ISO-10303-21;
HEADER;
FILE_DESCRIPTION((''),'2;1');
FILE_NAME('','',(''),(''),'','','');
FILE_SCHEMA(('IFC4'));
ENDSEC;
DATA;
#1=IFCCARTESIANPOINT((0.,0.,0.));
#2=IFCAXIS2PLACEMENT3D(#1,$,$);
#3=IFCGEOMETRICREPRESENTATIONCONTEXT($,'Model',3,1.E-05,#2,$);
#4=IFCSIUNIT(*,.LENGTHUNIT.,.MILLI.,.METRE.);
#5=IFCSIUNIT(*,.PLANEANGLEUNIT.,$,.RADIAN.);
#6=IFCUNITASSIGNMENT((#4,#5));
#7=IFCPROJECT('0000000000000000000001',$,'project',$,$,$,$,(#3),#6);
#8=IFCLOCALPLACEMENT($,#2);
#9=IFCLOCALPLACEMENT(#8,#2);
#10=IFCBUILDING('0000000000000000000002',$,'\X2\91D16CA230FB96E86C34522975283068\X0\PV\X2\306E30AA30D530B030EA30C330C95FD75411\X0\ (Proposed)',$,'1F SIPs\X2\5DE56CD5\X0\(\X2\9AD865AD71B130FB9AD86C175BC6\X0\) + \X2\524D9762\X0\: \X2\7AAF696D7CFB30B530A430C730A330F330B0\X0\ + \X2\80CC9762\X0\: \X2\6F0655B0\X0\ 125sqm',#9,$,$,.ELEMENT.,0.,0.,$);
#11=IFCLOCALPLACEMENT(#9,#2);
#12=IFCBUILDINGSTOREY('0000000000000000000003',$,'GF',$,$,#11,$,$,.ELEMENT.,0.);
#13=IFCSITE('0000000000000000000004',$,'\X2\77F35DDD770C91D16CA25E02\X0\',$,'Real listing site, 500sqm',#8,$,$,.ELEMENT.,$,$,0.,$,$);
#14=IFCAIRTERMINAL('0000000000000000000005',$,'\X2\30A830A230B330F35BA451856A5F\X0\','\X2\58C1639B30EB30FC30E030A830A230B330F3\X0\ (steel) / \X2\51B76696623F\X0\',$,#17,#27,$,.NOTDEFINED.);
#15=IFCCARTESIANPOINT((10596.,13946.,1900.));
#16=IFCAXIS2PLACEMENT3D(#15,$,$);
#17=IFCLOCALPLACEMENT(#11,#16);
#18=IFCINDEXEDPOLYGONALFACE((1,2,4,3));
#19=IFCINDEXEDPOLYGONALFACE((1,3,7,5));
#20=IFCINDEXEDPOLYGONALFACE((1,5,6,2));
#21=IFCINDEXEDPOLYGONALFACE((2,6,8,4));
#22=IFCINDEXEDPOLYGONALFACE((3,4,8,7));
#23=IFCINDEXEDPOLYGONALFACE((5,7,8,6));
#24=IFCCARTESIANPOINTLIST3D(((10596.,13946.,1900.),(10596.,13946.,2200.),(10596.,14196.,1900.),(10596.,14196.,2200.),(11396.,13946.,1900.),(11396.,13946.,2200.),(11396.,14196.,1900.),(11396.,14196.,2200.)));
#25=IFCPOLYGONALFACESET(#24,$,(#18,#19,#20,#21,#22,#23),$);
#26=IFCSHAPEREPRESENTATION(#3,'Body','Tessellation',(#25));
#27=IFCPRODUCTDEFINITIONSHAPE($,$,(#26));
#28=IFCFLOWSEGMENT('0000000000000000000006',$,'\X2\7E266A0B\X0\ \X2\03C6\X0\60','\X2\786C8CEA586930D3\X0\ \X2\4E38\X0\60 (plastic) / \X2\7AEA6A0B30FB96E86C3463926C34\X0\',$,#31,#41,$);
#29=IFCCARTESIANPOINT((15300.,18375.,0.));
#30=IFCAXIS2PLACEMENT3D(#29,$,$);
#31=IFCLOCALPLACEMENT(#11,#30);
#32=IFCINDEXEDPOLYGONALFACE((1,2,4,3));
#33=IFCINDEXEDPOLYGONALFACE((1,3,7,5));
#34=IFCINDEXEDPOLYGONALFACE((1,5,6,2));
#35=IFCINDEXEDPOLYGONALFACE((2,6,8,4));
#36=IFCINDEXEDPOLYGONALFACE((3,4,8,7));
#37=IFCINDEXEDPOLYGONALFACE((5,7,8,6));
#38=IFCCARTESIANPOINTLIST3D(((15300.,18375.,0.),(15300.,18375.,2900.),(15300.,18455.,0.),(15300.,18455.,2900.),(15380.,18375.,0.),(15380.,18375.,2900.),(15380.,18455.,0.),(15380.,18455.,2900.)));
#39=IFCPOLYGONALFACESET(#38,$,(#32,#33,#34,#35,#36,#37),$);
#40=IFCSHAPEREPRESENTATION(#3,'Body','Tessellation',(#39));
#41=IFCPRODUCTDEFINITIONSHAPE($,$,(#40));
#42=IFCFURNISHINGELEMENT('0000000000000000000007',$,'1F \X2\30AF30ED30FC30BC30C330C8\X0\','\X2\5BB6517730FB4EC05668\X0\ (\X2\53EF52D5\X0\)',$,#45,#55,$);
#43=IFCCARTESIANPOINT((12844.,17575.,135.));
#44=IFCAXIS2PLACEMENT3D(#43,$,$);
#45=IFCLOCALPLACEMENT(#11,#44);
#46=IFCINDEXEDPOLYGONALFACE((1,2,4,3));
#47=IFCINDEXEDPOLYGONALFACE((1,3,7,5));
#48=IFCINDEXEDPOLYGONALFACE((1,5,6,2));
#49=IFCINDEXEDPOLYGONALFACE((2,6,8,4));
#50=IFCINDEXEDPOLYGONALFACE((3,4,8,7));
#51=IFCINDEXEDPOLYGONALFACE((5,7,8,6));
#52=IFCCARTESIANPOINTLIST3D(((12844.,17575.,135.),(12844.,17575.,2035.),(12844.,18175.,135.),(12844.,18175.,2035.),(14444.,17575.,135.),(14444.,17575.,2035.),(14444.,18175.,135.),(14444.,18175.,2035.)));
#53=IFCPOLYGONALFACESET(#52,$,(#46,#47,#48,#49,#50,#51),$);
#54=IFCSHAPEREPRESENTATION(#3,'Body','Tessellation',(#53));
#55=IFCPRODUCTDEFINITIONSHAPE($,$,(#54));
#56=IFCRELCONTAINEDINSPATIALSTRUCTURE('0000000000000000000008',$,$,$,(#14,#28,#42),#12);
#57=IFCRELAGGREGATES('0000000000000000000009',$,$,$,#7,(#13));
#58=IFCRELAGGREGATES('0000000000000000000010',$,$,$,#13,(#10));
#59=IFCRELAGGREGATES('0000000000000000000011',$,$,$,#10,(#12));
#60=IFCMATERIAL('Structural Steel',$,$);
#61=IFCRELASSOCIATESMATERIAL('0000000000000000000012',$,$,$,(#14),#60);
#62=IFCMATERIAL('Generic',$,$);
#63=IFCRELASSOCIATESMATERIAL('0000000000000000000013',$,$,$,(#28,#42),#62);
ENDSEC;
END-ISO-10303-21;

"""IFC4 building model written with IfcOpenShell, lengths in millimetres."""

from ifc_helpers import new_model, si_unit, frame, frame_2d, origin, place, context, project, spatial, rectangle, extrude, material, element, save


model = new_model("IFC4")

# Units and contexts
model_context = context("Model", 3, precision=1e-05, world=origin())
ifc_project = project(units=[si_unit("LENGTHUNIT", "METRE", prefix="MILLI"), si_unit("PLANEANGLEUNIT", "RADIAN")], contexts=[model_context])

# Site, building, storey
site_placement = place(None, origin())
site = spatial("IfcSite", under=ifc_project, at=site_placement, Name="石川県金沢市", ObjectType="Real listing site, 500sqm", CompositionType="ELEMENT", RefElevation=0.0)
building_placement = place(site_placement, origin())
building = spatial("IfcBuilding", under=site, at=building_placement, Name="金沢・雨水利用とPVのオフグリッド志向 (Proposed)", ObjectType="1F SIPs工法(高断熱・高気密) + 前面: 窯業系サイディング + 背面: 漆喰 125sqm", CompositionType="ELEMENT", ElevationOfRefHeight=0.0, ElevationOfTerrain=0.0)
storey_placement = place(building_placement, origin())
storey = spatial("IfcBuildingStorey", under=building, at=storey_placement, Name="GF", CompositionType="ELEMENT", Elevation=0.0)

# Shared definitions
ifc_material_1 = material(Name="Structural Steel")

# Shared definitions
ifc_material_2 = material(Name="Generic")

# Air terminal
air_terminal_placement = place(storey_placement, frame((10596.0, 13946.0, 1900.0)))
element("IfcAirTerminal", 1, at=air_terminal_placement, inside=storey, material=ifc_material_1, Name="エアコン室内機", Description="壁掛ルームエアコン (steel) / 冷暖房", PredefinedType="NOTDEFINED", context=model_context, shape_type="SweptSolid", body=[
    extrude(rectangle(XDim=800.0, YDim=250.0, at=frame_2d((400.0, 125.0))), frame((10596.0, 13946.0, 1900.0)), (0.0, 0.0, 1.0), 300.0),
])

# Flow segment
flow_segment_placement = place(storey_placement, frame((15300.0, 18375.0, 0.0)))
element("IfcFlowSegment", 2, at=flow_segment_placement, inside=storey, material=ifc_material_2, Name="縦樋 φ60", Description="硬質塩ビ 丸60 (plastic) / 竪樋・雨水排水", context=model_context, shape_type="SweptSolid", body=[
    extrude(rectangle(XDim=80.0, YDim=80.0, at=frame_2d((40.0, 40.0))), frame((15300.0, 18375.0, 0.0)), (0.0, 0.0, 1.0), 2900.0),
])

# Furnishing element
furnishing_placement = place(storey_placement, frame((12844.0, 17575.0, 135.0)))
element("IfcFurnishingElement", 3, at=furnishing_placement, inside=storey, material=ifc_material_2, Name="1F クローゼット", Description="家具・什器 (可動)", context=model_context, shape_type="SweptSolid", body=[
    extrude(rectangle(XDim=1600.0, YDim=600.0, at=frame_2d((800.0, 300.0))), frame((12844.0, 17575.0, 135.0)), (0.0, 0.0, 1.0), 1900.0),
])

save(model, "model.ifc")
